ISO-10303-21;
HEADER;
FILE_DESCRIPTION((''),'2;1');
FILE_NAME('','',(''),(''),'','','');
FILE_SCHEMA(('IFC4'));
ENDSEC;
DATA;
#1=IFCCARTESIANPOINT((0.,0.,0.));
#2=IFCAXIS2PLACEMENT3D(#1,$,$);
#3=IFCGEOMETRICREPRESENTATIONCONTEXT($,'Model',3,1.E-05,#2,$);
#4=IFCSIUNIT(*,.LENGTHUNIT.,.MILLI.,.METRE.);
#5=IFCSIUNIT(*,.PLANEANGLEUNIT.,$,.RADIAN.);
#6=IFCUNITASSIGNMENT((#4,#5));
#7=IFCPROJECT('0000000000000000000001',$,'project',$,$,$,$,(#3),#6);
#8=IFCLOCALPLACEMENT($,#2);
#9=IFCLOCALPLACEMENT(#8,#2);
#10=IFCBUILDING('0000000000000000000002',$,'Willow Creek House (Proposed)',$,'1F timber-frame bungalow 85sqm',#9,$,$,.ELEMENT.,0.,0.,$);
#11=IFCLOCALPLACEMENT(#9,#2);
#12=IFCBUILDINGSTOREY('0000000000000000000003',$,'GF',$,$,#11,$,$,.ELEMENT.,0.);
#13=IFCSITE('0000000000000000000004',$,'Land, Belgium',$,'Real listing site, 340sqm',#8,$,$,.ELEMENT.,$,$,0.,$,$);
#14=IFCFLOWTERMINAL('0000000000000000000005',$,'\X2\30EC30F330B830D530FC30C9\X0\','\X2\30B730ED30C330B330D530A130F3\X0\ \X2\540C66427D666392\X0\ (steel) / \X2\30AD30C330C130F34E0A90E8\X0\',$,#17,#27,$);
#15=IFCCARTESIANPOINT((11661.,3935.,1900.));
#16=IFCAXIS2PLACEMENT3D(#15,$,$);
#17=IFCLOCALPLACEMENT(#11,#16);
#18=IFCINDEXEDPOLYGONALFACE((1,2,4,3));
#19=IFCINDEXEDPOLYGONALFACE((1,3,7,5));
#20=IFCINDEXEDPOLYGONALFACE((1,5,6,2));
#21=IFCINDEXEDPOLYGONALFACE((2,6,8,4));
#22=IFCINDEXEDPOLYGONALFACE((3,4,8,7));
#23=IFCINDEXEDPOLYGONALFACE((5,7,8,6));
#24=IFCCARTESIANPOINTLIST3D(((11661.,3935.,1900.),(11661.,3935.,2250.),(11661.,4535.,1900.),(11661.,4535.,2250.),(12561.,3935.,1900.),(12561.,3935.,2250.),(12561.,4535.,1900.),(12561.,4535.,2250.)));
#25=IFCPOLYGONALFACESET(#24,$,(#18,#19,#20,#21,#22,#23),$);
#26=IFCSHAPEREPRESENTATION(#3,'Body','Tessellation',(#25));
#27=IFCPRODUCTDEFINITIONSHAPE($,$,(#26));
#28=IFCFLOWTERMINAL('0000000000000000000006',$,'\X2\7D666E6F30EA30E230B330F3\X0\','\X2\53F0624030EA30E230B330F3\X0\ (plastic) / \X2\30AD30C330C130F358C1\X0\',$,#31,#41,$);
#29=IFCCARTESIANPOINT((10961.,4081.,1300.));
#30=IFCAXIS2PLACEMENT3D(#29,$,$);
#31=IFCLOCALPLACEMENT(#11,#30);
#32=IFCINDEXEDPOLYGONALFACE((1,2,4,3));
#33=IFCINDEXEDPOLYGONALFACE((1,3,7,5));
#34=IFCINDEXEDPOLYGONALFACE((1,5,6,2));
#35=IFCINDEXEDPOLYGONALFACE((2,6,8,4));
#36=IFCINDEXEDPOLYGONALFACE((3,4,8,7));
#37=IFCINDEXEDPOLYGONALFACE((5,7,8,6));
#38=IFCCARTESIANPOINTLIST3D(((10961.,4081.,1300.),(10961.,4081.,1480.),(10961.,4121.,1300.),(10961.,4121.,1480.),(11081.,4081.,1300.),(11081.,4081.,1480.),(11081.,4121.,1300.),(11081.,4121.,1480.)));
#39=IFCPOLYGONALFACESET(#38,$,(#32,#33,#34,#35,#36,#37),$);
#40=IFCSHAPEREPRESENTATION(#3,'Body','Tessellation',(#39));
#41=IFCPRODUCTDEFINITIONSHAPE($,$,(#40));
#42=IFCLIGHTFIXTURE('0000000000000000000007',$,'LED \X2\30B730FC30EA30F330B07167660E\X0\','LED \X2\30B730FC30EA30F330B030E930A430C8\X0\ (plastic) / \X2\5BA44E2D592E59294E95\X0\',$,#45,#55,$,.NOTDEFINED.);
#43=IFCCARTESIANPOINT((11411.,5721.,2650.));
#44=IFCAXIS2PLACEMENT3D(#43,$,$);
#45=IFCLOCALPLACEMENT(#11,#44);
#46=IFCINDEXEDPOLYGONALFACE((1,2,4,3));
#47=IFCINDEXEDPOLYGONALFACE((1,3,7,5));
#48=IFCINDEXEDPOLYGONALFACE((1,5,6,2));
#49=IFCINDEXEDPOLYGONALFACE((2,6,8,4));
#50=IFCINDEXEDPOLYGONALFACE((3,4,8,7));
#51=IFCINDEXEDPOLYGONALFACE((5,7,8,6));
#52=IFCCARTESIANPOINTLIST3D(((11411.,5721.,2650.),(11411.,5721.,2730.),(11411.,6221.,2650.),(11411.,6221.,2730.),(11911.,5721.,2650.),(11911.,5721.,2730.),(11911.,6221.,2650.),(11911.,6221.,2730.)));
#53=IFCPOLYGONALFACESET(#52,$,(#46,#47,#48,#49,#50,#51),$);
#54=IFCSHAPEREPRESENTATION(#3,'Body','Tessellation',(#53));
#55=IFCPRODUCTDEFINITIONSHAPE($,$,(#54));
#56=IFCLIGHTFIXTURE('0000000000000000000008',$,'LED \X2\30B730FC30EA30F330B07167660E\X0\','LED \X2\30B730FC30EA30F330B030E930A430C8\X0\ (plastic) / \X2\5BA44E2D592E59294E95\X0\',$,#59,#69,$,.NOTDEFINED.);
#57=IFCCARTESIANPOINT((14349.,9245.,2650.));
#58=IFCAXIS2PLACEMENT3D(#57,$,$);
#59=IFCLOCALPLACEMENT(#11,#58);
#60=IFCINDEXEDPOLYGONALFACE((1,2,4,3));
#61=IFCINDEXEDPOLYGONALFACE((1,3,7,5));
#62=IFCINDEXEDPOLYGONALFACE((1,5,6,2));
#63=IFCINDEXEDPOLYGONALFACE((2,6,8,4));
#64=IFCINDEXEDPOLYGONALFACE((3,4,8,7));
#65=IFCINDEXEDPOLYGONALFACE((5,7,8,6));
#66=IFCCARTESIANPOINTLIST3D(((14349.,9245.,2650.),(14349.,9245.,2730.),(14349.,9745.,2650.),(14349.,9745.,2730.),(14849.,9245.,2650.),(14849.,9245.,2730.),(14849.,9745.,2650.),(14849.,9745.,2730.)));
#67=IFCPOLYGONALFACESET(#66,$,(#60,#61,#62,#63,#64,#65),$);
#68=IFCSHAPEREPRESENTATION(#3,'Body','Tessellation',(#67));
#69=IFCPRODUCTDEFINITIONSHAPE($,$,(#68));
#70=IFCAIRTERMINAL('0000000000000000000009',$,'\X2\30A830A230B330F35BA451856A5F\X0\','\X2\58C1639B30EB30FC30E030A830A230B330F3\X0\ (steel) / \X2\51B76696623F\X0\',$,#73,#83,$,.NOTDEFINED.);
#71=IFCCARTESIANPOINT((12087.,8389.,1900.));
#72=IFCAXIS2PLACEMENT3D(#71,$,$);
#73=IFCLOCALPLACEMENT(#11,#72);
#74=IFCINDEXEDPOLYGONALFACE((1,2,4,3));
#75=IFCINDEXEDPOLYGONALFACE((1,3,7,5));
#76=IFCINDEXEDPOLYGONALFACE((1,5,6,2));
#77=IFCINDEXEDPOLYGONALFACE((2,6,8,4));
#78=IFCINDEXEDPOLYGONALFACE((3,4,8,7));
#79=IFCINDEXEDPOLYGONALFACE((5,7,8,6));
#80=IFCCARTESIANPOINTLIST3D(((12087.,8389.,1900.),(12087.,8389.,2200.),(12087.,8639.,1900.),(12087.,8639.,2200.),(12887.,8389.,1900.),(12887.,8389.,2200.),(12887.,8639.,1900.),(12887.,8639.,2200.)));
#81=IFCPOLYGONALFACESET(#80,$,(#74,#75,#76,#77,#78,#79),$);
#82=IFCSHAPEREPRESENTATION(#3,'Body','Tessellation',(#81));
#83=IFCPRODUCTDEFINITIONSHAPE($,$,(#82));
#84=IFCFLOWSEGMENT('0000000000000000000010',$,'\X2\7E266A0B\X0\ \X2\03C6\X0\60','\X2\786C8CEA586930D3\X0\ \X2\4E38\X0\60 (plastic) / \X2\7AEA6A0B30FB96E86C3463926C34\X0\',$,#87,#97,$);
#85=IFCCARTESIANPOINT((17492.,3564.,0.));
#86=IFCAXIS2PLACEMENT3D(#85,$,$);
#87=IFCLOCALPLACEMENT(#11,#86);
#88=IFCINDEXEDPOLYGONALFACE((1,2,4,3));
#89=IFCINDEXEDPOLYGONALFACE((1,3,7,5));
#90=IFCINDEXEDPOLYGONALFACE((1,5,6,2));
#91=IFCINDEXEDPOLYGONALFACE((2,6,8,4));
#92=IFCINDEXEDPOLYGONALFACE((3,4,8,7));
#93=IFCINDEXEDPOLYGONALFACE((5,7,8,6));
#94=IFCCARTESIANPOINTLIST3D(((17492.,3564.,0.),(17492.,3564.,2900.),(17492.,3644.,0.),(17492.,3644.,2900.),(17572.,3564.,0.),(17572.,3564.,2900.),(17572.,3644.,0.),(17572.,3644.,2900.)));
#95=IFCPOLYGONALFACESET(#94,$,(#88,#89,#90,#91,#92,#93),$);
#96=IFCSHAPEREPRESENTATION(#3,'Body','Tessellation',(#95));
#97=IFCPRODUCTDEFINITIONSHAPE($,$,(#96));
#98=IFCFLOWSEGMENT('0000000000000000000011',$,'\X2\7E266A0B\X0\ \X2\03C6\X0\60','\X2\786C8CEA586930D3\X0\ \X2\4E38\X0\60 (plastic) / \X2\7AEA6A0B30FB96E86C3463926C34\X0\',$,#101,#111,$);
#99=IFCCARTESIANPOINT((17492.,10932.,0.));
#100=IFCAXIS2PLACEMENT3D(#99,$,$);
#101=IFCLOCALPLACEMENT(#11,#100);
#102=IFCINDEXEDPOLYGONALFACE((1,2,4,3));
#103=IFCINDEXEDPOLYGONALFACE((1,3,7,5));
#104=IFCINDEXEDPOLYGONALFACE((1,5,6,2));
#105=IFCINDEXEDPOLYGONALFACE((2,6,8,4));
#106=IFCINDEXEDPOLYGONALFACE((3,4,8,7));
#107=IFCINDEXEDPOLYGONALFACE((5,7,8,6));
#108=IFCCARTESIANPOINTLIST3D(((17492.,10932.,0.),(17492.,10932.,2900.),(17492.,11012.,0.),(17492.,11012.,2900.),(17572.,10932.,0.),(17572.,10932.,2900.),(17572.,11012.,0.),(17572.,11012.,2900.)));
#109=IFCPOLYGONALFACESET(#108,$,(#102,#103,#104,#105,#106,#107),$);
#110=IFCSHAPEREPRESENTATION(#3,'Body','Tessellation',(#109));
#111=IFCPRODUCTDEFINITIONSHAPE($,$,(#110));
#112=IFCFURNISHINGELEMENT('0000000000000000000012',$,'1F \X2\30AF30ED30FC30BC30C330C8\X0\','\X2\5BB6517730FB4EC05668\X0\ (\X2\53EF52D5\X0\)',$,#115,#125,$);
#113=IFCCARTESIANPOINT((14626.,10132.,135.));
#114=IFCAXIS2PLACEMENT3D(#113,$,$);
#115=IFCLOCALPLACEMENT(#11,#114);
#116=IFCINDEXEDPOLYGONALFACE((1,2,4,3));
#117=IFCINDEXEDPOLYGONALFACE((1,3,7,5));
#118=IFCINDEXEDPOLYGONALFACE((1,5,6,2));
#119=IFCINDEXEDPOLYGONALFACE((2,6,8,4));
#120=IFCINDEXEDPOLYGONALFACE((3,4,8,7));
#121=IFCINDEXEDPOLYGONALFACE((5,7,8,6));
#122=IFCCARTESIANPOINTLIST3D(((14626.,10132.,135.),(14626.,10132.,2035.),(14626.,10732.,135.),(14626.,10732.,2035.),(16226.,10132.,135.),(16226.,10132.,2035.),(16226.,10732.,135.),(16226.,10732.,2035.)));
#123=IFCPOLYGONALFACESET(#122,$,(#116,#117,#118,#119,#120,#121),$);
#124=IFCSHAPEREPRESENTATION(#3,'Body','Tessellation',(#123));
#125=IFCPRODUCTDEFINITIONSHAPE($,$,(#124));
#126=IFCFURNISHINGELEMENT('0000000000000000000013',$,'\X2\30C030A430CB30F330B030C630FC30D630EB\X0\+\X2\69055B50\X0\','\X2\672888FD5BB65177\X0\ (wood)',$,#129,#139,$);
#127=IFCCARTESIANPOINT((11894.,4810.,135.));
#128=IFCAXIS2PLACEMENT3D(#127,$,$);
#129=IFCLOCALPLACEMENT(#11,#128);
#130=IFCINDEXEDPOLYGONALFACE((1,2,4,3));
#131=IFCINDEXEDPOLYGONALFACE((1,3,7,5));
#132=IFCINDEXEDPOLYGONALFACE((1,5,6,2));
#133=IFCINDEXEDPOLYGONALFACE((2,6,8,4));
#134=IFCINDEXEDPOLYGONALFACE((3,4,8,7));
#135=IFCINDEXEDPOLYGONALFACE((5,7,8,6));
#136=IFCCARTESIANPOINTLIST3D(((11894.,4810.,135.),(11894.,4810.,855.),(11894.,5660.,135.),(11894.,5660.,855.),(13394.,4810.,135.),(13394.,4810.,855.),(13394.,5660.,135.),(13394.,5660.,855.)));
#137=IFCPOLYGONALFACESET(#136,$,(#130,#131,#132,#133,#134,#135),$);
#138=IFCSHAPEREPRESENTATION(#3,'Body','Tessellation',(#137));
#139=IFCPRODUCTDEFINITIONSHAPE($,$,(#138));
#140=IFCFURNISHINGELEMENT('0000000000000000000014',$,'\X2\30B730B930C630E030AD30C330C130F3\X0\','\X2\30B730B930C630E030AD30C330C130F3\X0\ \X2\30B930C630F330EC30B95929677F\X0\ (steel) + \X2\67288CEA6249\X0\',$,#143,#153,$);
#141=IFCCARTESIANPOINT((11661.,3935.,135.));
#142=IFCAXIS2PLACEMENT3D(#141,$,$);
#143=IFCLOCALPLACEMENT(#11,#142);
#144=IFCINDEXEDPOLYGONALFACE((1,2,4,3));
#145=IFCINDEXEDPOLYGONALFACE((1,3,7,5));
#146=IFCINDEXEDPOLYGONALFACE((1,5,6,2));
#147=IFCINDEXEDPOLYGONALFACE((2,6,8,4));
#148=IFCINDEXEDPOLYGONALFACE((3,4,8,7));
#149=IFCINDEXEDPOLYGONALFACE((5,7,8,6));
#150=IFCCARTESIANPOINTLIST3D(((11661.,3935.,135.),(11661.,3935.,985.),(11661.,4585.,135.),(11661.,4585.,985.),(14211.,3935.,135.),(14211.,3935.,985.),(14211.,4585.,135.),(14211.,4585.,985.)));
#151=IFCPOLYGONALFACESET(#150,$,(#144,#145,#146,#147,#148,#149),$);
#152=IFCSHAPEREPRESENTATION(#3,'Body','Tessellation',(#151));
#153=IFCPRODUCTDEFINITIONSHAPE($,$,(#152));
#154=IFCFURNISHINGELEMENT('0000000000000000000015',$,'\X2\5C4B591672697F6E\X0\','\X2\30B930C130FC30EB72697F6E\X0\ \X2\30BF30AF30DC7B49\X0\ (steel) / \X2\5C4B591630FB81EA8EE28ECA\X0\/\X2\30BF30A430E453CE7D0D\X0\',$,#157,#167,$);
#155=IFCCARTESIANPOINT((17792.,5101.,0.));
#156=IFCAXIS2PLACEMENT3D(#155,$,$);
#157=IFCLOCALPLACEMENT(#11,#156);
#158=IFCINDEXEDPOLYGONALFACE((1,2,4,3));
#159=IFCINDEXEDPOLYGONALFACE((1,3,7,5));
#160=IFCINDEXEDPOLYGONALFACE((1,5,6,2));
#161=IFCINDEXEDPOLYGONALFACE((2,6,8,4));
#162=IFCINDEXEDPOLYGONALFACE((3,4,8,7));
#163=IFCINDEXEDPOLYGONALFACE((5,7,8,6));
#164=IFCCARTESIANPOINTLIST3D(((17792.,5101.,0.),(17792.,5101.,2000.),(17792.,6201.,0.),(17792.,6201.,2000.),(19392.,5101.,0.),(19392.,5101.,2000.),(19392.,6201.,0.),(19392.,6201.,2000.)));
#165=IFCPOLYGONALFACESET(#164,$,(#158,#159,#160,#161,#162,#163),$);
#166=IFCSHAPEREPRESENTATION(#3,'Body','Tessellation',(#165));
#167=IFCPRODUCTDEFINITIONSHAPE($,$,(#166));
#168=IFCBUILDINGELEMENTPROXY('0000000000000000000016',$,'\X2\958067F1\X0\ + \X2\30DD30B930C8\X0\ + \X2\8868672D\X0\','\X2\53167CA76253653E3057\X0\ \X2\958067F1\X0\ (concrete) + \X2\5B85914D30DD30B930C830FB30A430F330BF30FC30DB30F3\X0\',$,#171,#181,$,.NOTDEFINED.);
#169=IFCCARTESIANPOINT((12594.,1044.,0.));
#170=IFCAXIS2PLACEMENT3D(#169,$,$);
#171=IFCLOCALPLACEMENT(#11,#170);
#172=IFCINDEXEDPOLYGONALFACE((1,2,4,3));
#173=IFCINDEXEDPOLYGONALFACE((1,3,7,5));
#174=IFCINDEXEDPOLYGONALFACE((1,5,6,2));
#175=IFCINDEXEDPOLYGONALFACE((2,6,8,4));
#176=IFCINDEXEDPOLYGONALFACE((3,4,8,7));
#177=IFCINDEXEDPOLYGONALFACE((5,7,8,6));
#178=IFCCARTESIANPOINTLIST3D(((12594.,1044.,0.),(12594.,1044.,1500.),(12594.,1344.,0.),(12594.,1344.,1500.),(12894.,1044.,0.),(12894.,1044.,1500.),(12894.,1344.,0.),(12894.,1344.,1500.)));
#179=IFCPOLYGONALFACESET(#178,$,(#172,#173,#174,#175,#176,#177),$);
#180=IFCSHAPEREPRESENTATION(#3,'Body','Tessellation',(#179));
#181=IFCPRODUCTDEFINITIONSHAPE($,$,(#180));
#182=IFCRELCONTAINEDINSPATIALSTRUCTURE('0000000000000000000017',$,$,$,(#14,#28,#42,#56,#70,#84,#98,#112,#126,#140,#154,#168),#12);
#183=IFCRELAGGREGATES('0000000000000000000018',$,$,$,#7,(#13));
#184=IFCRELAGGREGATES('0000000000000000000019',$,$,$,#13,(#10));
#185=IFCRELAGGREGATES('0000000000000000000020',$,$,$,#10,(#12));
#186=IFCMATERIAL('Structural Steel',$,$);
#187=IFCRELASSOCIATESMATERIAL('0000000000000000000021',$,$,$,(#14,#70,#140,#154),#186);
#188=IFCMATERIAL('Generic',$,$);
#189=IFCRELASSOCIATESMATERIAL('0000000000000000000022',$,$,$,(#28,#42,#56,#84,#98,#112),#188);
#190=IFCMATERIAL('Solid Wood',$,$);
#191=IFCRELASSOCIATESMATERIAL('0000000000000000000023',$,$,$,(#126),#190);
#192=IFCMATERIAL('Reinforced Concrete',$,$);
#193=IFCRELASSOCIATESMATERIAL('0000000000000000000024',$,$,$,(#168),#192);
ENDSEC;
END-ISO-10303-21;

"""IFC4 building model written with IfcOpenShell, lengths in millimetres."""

from ifc_helpers import new_model, si_unit, frame, frame_2d, origin, place, context, project, spatial, rectangle, extrude, material, element, save


model = new_model("IFC4")

# Units and contexts
model_context = context("Model", 3, precision=1e-05, world=origin())
ifc_project = project(units=[si_unit("LENGTHUNIT", "METRE", prefix="MILLI"), si_unit("PLANEANGLEUNIT", "RADIAN")], contexts=[model_context])

# Site, building, storey
site_placement = place(None, origin())
site = spatial("IfcSite", under=ifc_project, at=site_placement, Name="Land, Belgium", ObjectType="Real listing site, 340sqm", CompositionType="ELEMENT", RefElevation=0.0)
building_placement = place(site_placement, origin())
building = spatial("IfcBuilding", under=site, at=building_placement, Name="Willow Creek House (Proposed)", ObjectType="1F timber-frame bungalow 85sqm", CompositionType="ELEMENT", ElevationOfRefHeight=0.0, ElevationOfTerrain=0.0)
storey_placement = place(building_placement, origin())
storey = spatial("IfcBuildingStorey", under=building, at=storey_placement, Name="GF", CompositionType="ELEMENT", Elevation=0.0)

# Shared definitions
ifc_material_1 = material(Name="Solid Wood")

# Shared definitions
ifc_material_2 = material(Name="Reinforced Concrete")

# Shared definitions
ifc_material_3 = material(Name="Generic")

# Shared definitions
ifc_material_4 = material(Name="Structural Steel")

# Flow terminals
flow_terminal_1_placement = place(storey_placement, frame((11661.0, 3935.0, 1900.0)))
element("IfcFlowTerminal", 1, at=flow_terminal_1_placement, inside=storey, material=ifc_material_4, Name="レンジフード", Description="シロッコファン 同時給排 (steel) / キッチン上部", context=model_context, shape_type="SweptSolid", body=[
    extrude(rectangle(XDim=900.0, YDim=600.0, at=frame_2d((450.0, 300.0))), frame((11661.0, 3935.0, 1900.0)), (0.0, 0.0, 1.0), 350.0),
])
flow_terminal_2_placement = place(storey_placement, frame((10961.0, 4081.0, 1300.0)))
element("IfcFlowTerminal", 2, at=flow_terminal_2_placement, inside=storey, material=ifc_material_3, Name="給湯リモコン", Description="台所リモコン (plastic) / キッチン壁", context=model_context, shape_type="SweptSolid", body=[
    extrude(rectangle(XDim=120.0, YDim=40.0, at=frame_2d((60.0, 20.0))), frame((10961.0, 4081.0, 1300.0)), (0.0, 0.0, 1.0), 180.0),
])

# Light fixtures
light_fixture_1_placement = place(storey_placement, frame((11411.0, 5721.0, 2650.0)))
element("IfcLightFixture", 3, at=light_fixture_1_placement, inside=storey, material=ifc_material_3, Name="LED シーリング照明", Description="LED シーリングライト (plastic) / 室中央天井", PredefinedType="NOTDEFINED", context=model_context, shape_type="SweptSolid", body=[
    extrude(rectangle(XDim=500.0, YDim=500.0, at=frame_2d((250.0, 250.0))), frame((11411.0, 5721.0, 2650.0)), (0.0, 0.0, 1.0), 80.0),
])
light_fixture_2_placement = place(storey_placement, frame((14349.0, 9245.0, 2650.0)))
element("IfcLightFixture", 4, at=light_fixture_2_placement, inside=storey, material=ifc_material_3, Name="LED シーリング照明", Description="LED シーリングライト (plastic) / 室中央天井", PredefinedType="NOTDEFINED", context=model_context, shape_type="SweptSolid", body=[
    extrude(rectangle(XDim=500.0, YDim=500.0, at=frame_2d((250.0, 250.0))), frame((14349.0, 9245.0, 2650.0)), (0.0, 0.0, 1.0), 80.0),
])

# Air terminal
air_terminal_placement = place(storey_placement, frame((12087.0, 8389.0, 1900.0)))
element("IfcAirTerminal", 5, at=air_terminal_placement, inside=storey, material=ifc_material_4, Name="エアコン室内機", Description="壁掛ルームエアコン (steel) / 冷暖房", PredefinedType="NOTDEFINED", context=model_context, shape_type="SweptSolid", body=[
    extrude(rectangle(XDim=800.0, YDim=250.0, at=frame_2d((400.0, 125.0))), frame((12087.0, 8389.0, 1900.0)), (0.0, 0.0, 1.0), 300.0),
])

# Flow segments
flow_segment_1_placement = place(storey_placement, frame((17492.0, 3564.0, 0.0)))
element("IfcFlowSegment", 6, at=flow_segment_1_placement, inside=storey, material=ifc_material_3, Name="縦樋 φ60", Description="硬質塩ビ 丸60 (plastic) / 竪樋・雨水排水", context=model_context, shape_type="SweptSolid", body=[
    extrude(rectangle(XDim=80.0, YDim=80.0, at=frame_2d((40.0, 40.0))), frame((17492.0, 3564.0, 0.0)), (0.0, 0.0, 1.0), 2900.0),
])
flow_segment_2_placement = place(storey_placement, frame((17492.0, 10932.0, 0.0)))
element("IfcFlowSegment", 7, at=flow_segment_2_placement, inside=storey, material=ifc_material_3, Name="縦樋 φ60", Description="硬質塩ビ 丸60 (plastic) / 竪樋・雨水排水", context=model_context, shape_type="SweptSolid", body=[
    extrude(rectangle(XDim=80.0, YDim=80.0, at=frame_2d((40.0, 40.0))), frame((17492.0, 10932.0, 0.0)), (0.0, 0.0, 1.0), 2900.0),
])

# Furnishing elements
furnishing_1_placement = place(storey_placement, frame((14626.0, 10132.0, 135.0)))
element("IfcFurnishingElement", 8, at=furnishing_1_placement, inside=storey, material=ifc_material_3, Name="1F クローゼット", Description="家具・什器 (可動)", context=model_context, shape_type="SweptSolid", body=[
    extrude(rectangle(XDim=1600.0, YDim=600.0, at=frame_2d((800.0, 300.0))), frame((14626.0, 10132.0, 135.0)), (0.0, 0.0, 1.0), 1900.0),
])
furnishing_2_placement = place(storey_placement, frame((11894.0, 4810.0, 135.0)))
element("IfcFurnishingElement", 9, at=furnishing_2_placement, inside=storey, material=ifc_material_1, Name="ダイニングテーブル+椅子", Description="木製家具 (wood)", context=model_context, shape_type="SweptSolid", body=[
    extrude(rectangle(XDim=1500.0, YDim=850.0, at=frame_2d((750.0, 425.0))), frame((11894.0, 4810.0, 135.0)), (0.0, 0.0, 1.0), 720.0),
])
furnishing_3_placement = place(storey_placement, frame((11661.0, 3935.0, 135.0)))
element("IfcFurnishingElement", 10, at=furnishing_3_placement, inside=storey, material=ifc_material_4, Name="システムキッチン", Description="システムキッチン ステンレス天板 (steel) + 木質扉", context=model_context, shape_type="SweptSolid", body=[
    extrude(rectangle(XDim=2550.0, YDim=650.0, at=frame_2d((1275.0, 325.0))), frame((11661.0, 3935.0, 135.0)), (0.0, 0.0, 1.0), 850.0),
])
furnishing_4_placement = place(storey_placement, frame((17792.0, 5101.0, 0.0)))
element("IfcFurnishingElement", 11, at=furnishing_4_placement, inside=storey, material=ifc_material_4, Name="屋外物置", Description="スチール物置 タクボ等 (steel) / 屋外・自転車/タイヤ収納", context=model_context, shape_type="SweptSolid", body=[
    extrude(rectangle(XDim=1600.0, YDim=1100.0, at=frame_2d((800.0, 550.0))), frame((17792.0, 5101.0, 0.0)), (0.0, 0.0, 1.0), 2000.0),
])

# Building element proxy
proxy_placement = place(storey_placement, frame((12594.0, 1044.0, 0.0)))
element("IfcBuildingElementProxy", 12, at=proxy_placement, inside=storey, material=ifc_material_2, Name="門柱 + ポスト + 表札", Description="化粧打放し 門柱 (concrete) + 宅配ポスト・インターホン", PredefinedType="NOTDEFINED", context=model_context, shape_type="SweptSolid", body=[
    extrude(rectangle(XDim=300.0, YDim=300.0, at=frame_2d((150.0, 150.0))), frame((12594.0, 1044.0, 0.0)), (0.0, 0.0, 1.0), 1500.0),
])

save(model, "model.ifc")
